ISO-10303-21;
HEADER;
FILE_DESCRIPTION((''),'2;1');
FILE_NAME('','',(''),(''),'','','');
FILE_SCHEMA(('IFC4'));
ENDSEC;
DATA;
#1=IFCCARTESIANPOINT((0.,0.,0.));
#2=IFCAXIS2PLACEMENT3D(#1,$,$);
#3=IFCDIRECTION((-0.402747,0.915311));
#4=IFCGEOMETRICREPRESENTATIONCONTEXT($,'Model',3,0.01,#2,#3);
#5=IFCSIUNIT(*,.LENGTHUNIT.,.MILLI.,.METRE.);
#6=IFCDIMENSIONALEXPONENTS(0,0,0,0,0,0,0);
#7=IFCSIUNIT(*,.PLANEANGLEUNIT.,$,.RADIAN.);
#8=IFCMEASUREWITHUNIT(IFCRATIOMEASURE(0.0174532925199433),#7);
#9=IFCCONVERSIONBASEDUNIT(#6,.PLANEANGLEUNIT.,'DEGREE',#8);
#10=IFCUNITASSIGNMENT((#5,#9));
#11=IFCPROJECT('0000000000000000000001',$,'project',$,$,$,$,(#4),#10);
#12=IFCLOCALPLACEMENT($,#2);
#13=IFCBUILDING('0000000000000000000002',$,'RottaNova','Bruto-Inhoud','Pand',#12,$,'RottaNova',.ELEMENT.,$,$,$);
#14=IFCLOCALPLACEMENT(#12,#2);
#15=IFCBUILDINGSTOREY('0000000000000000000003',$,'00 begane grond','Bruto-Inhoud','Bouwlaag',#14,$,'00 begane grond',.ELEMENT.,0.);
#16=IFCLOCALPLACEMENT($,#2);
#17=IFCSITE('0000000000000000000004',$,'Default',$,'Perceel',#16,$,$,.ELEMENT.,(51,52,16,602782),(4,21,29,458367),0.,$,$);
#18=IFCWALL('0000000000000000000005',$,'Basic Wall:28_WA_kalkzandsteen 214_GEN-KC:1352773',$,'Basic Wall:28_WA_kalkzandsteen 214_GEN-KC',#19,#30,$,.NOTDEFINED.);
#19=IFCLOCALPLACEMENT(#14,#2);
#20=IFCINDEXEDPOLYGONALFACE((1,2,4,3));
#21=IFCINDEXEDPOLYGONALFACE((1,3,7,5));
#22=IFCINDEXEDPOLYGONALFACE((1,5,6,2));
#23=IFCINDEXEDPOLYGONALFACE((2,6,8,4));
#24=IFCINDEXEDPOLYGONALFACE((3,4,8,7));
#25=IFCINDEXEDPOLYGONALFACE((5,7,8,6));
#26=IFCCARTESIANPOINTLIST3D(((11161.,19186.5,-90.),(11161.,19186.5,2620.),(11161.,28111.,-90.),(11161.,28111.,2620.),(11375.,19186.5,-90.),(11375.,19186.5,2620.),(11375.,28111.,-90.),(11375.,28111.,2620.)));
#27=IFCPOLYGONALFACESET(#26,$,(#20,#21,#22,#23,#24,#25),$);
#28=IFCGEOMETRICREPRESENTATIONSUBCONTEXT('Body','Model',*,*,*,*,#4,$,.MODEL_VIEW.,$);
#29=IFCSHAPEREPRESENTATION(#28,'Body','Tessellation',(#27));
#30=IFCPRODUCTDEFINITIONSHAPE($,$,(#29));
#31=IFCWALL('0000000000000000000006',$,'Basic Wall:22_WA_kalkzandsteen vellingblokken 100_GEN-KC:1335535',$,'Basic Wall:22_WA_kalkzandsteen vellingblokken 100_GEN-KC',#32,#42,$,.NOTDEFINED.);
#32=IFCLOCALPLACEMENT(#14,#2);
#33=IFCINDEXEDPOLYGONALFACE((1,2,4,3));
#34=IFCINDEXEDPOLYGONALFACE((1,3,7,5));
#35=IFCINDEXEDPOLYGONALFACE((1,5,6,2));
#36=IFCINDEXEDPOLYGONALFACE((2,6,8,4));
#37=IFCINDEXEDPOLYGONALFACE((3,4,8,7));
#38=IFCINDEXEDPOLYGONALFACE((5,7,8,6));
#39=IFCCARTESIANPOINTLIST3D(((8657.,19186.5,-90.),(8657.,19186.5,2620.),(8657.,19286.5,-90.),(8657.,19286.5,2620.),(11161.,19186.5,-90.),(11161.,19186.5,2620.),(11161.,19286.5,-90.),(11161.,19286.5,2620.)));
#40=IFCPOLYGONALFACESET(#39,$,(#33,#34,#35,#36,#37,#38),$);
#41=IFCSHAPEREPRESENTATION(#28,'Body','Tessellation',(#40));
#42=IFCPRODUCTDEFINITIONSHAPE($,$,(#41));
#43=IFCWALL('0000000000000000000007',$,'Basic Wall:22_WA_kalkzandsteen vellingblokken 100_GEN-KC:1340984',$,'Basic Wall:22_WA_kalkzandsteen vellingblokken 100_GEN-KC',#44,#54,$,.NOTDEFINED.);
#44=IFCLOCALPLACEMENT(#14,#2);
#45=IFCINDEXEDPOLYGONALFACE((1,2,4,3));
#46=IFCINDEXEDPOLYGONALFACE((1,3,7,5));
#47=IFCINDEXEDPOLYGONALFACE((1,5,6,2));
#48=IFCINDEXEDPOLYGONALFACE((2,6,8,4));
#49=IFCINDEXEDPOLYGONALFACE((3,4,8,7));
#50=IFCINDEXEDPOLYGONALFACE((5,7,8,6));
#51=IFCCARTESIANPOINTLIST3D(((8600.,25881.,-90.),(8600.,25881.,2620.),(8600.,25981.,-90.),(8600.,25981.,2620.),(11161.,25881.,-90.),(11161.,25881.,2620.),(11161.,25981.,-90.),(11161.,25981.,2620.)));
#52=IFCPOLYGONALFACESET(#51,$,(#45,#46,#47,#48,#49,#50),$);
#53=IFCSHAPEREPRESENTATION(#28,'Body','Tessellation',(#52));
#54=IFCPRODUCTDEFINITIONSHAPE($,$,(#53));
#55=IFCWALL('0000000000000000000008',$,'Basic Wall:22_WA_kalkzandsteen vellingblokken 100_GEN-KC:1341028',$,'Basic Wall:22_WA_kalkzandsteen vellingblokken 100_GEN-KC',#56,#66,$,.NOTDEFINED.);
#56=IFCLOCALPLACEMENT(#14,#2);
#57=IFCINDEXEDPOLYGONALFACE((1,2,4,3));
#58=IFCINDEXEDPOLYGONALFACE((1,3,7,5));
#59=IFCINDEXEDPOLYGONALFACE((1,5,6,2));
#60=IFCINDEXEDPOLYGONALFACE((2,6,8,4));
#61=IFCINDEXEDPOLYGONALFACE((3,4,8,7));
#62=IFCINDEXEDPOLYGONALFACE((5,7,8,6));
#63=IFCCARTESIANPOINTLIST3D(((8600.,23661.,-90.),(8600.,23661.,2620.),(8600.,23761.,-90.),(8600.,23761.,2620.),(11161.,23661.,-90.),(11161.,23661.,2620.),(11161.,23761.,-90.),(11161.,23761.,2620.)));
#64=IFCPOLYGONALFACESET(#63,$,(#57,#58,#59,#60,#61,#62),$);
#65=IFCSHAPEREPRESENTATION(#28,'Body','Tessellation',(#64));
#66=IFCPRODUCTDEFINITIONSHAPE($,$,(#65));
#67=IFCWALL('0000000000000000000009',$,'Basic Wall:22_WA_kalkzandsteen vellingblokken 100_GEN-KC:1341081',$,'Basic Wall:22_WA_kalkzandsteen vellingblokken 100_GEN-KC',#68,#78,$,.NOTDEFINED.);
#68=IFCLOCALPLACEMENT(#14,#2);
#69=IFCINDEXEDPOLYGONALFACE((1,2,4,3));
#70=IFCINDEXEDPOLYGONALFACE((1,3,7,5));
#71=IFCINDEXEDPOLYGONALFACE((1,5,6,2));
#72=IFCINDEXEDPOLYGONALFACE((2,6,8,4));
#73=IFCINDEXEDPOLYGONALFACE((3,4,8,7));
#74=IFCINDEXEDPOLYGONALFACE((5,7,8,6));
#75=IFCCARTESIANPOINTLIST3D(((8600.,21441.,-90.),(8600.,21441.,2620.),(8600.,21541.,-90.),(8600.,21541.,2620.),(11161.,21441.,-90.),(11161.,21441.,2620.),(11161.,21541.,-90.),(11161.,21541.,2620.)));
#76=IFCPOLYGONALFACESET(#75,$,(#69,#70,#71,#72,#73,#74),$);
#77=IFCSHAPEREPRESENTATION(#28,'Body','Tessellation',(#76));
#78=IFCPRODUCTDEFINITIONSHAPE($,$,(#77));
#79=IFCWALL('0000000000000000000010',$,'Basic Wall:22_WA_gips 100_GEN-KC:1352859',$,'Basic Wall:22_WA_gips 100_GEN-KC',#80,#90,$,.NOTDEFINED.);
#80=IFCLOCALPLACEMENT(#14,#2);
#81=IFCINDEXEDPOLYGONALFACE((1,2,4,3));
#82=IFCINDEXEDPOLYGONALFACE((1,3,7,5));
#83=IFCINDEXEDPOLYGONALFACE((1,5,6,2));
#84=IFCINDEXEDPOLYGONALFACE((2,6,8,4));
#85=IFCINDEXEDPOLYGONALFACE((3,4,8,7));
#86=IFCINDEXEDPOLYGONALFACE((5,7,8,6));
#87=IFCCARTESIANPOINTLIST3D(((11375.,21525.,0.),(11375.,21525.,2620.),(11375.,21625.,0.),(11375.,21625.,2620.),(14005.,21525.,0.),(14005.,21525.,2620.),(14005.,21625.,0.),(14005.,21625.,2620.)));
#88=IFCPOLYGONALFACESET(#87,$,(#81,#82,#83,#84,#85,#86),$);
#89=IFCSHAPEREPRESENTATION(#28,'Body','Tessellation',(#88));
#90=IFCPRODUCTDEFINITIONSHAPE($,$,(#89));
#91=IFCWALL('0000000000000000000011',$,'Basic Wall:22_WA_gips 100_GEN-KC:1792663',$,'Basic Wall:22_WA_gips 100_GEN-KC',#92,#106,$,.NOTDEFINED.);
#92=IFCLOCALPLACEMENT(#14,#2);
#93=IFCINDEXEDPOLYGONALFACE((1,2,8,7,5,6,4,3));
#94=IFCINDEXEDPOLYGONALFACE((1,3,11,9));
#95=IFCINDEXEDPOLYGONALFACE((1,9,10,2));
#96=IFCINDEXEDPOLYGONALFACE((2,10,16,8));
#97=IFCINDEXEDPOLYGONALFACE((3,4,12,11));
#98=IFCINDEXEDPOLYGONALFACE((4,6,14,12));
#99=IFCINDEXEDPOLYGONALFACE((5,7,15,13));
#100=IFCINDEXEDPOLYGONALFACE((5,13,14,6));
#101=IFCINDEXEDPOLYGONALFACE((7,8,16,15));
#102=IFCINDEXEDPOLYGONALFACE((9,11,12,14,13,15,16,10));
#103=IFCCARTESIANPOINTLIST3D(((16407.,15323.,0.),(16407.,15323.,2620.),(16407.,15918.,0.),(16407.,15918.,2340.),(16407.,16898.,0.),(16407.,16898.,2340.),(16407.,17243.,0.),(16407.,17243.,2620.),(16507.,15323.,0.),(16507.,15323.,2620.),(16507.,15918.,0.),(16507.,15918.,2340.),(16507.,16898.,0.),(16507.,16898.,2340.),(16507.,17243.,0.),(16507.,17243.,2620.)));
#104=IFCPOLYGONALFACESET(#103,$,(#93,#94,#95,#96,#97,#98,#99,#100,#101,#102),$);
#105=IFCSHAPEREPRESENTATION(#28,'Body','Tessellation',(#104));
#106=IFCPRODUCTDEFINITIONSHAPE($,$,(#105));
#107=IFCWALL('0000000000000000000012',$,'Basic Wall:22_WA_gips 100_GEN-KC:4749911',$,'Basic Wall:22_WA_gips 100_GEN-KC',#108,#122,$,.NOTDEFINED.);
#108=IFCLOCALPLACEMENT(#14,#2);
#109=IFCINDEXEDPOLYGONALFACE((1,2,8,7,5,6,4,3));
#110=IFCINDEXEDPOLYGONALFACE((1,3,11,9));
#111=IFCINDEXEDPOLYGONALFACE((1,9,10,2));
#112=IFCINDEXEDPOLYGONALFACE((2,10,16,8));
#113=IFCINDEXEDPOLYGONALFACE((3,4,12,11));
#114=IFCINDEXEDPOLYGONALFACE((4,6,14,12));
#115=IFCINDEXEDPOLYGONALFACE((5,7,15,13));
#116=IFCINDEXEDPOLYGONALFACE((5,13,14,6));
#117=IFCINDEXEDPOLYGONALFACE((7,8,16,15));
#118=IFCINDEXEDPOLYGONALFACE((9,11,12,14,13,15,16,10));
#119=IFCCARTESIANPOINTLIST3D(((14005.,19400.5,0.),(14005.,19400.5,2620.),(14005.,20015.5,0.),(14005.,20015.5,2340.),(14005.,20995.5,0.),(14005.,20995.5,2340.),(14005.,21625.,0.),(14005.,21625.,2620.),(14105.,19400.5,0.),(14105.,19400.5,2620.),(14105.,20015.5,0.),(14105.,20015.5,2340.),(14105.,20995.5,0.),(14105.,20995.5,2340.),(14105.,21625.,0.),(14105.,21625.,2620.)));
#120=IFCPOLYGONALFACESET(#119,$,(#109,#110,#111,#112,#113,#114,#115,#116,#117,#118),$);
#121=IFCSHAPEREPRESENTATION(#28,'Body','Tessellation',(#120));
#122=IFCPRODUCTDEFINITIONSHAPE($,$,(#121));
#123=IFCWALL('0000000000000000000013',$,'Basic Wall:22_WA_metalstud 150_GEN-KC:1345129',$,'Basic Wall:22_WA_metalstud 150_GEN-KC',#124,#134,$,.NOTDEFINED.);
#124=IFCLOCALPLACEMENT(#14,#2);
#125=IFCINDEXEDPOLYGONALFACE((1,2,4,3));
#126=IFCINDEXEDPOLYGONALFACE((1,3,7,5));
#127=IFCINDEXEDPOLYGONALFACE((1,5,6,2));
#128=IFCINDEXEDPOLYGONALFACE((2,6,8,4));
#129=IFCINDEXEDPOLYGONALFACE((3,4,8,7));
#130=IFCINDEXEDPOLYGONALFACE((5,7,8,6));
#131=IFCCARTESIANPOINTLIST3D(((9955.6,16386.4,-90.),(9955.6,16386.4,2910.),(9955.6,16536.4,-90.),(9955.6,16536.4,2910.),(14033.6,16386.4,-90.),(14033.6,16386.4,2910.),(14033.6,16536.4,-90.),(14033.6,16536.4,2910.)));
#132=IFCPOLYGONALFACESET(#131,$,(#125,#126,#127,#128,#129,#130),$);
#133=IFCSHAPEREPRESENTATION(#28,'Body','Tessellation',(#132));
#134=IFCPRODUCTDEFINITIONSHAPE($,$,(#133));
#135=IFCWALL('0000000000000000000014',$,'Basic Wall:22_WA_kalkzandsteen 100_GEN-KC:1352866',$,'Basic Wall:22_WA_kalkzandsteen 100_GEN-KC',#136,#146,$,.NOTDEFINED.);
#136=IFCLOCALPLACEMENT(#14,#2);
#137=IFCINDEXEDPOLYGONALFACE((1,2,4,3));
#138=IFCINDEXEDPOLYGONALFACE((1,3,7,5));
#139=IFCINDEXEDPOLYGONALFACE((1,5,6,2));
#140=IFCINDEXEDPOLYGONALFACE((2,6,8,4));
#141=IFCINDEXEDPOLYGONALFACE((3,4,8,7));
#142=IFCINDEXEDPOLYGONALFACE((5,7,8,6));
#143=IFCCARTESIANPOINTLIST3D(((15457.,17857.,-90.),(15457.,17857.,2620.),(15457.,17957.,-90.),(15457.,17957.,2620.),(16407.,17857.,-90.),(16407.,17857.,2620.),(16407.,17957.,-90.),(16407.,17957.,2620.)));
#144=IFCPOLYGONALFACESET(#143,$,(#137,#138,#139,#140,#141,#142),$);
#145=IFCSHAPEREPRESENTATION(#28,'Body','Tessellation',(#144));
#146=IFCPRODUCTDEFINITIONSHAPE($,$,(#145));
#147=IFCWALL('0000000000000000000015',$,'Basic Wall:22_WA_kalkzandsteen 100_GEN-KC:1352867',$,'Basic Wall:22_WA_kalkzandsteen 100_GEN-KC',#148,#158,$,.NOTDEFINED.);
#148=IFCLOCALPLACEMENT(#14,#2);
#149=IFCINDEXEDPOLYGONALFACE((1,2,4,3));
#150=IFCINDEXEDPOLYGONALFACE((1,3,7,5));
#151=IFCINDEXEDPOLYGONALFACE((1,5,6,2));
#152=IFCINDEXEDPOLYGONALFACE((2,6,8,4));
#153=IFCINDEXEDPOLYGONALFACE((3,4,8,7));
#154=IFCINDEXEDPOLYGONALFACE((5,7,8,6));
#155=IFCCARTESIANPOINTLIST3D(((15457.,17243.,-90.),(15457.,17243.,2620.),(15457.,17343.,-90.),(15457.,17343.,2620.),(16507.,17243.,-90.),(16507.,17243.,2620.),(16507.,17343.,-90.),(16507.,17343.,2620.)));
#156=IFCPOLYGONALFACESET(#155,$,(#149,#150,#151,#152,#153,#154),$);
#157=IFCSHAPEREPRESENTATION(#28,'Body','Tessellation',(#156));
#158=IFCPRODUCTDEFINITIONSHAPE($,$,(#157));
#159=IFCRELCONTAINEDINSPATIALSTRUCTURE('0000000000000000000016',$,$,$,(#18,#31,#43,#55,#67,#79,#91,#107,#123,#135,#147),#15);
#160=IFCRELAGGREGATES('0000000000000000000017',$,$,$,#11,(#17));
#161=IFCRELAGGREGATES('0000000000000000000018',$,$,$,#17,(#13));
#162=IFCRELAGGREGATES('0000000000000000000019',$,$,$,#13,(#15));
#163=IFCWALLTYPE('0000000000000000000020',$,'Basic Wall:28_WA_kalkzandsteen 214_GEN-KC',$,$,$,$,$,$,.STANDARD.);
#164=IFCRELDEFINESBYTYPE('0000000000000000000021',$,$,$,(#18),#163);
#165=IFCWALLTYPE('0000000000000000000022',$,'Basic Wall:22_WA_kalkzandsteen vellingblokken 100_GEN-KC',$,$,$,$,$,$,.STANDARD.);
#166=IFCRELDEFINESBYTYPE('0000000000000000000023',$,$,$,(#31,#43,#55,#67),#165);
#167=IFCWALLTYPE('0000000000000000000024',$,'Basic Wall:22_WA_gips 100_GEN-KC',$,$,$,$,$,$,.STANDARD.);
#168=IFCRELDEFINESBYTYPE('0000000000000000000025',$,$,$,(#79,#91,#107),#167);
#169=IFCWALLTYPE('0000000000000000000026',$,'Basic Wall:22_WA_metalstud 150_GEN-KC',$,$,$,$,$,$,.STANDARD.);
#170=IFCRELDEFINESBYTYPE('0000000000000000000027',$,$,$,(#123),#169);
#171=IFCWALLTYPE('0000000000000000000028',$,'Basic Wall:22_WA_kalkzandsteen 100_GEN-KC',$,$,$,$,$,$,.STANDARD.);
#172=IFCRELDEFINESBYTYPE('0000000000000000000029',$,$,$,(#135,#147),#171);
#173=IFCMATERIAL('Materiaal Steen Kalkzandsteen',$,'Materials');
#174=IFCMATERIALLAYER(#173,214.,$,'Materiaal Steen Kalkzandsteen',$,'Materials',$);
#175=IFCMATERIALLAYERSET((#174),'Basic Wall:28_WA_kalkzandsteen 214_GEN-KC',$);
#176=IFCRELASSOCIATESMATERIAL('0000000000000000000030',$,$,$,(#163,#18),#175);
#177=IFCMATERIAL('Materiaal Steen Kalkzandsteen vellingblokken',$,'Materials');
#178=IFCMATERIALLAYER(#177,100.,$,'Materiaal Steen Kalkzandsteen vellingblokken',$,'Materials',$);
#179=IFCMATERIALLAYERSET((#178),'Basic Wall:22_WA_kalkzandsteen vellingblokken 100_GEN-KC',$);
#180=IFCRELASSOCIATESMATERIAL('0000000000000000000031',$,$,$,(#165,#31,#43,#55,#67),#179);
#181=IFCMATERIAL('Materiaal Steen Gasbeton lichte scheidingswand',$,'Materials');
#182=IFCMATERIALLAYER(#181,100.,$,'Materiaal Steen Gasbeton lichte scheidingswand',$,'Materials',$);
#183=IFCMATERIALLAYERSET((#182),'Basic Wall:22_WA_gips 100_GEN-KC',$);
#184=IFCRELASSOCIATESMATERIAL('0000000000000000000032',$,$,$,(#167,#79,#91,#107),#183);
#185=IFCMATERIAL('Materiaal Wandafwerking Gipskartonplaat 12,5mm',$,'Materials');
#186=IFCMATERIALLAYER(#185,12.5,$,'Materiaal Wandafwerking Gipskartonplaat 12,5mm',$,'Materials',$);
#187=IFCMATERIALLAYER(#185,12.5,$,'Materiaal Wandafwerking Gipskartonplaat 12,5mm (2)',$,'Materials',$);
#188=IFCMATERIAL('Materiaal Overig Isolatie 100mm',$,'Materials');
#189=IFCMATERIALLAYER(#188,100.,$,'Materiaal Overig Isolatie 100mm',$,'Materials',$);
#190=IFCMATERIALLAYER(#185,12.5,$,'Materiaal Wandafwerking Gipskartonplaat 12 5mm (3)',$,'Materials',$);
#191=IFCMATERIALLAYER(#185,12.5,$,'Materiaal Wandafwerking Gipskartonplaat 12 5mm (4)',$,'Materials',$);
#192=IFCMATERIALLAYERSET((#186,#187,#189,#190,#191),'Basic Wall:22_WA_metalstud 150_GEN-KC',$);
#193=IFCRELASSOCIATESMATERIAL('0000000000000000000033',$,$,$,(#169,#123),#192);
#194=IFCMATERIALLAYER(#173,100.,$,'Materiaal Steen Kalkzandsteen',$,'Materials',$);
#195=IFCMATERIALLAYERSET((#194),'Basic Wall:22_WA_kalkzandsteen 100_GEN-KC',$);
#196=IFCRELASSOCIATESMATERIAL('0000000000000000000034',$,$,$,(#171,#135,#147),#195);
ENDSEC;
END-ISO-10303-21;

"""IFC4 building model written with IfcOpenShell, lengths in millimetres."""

from ifc_helpers import new_model, entity, si_unit, converted_unit, direction, frame, frame_2d, origin, place, context, subcontext, project, spatial, rectangle, extrude, material, layer, layer_set, type_object, element, save


model = new_model("IFC4")

# Units and contexts
model_context = context("Model", 3, precision=0.01, world=origin(), true_north=direction((-0.402747, 0.915311)))
body_context = subcontext(model_context, "Body", "Model", "MODEL_VIEW")
ifc_project = project(units=[si_unit("LENGTHUNIT", "METRE", prefix="MILLI"), converted_unit("PLANEANGLEUNIT", "DEGREE", entity("IfcRatioMeasure", 0.0174532925199433), si_unit("PLANEANGLEUNIT", "RADIAN"), dimensions=[0, 0, 0, 0, 0, 0, 0])], contexts=[model_context])

# Site, building, storey
site_placement = place(None, origin())
site = spatial("IfcSite", under=ifc_project, at=site_placement, Name="Default", ObjectType="Perceel", CompositionType="ELEMENT", RefLatitude=(51, 52, 16, 602782), RefLongitude=(4, 21, 29, 458367), RefElevation=0.0)
building_placement = place(None, origin())
building = spatial("IfcBuilding", under=site, at=building_placement, Name="RottaNova", Description="Bruto-Inhoud", ObjectType="Pand", LongName="RottaNova", CompositionType="ELEMENT")
storey_placement = place(building_placement, origin())
storey = spatial("IfcBuildingStorey", under=building, at=storey_placement, Name="00 begane grond", Description="Bruto-Inhoud", ObjectType="Bouwlaag", LongName="00 begane grond", CompositionType="ELEMENT", Elevation=0.0)

# Walls
ifc_material_1 = material(Name="Materiaal Steen Kalkzandsteen", Category="Materials")
ifc_layer_1 = layer(ifc_material_1, 214.0, Name="Materiaal Steen Kalkzandsteen", Category="Materials")
ifc_layer_set_1 = layer_set([ifc_layer_1], Name="Basic Wall:28_WA_kalkzandsteen 214_GEN-KC")
wall_type_1 = type_object("IfcWallType", Name="Basic Wall:28_WA_kalkzandsteen 214_GEN-KC", PredefinedType="STANDARD", material=ifc_layer_set_1)
wall_1_placement = place(storey_placement, frame((11268.0, 19186.5, -90.0), z_axis=(0.0, 0.0, 1.0), x_axis=(0.0, 1.0, 0.0)))
element("IfcWall", 1, at=wall_1_placement, inside=storey, type_object=wall_type_1, material=ifc_layer_set_1, Name="Basic Wall:28_WA_kalkzandsteen 214_GEN-KC:1352773", ObjectType="Basic Wall:28_WA_kalkzandsteen 214_GEN-KC", PredefinedType="NOTDEFINED", context=body_context, shape_type="SweptSolid", body=[
    extrude(rectangle(XDim=8924.5, YDim=214.0, at=frame_2d((4462.2, 0.0), x_axis=(-1.0, 0.0))), origin(), (0.0, 0.0, 1.0), 2710.0),
])
ifc_material_2 = material(Name="Materiaal Steen Kalkzandsteen vellingblokken", Category="Materials")
ifc_layer_2 = layer(ifc_material_2, 100.0, Name="Materiaal Steen Kalkzandsteen vellingblokken", Category="Materials")
ifc_layer_set_2 = layer_set([ifc_layer_2], Name="Basic Wall:22_WA_kalkzandsteen vellingblokken 100_GEN-KC")
wall_type_2 = type_object("IfcWallType", Name="Basic Wall:22_WA_kalkzandsteen vellingblokken 100_GEN-KC", PredefinedType="STANDARD", material=ifc_layer_set_2)
wall_2_placement = place(storey_placement, frame((8657.0, 19236.5, -90.0)))
element("IfcWall", 2, at=wall_2_placement, inside=storey, type_object=wall_type_2, material=ifc_layer_set_2, Name="Basic Wall:22_WA_kalkzandsteen vellingblokken 100_GEN-KC:1335535", ObjectType="Basic Wall:22_WA_kalkzandsteen vellingblokken 100_GEN-KC", PredefinedType="NOTDEFINED", context=body_context, shape_type="SweptSolid", body=[
    extrude(rectangle(XDim=2504.0, YDim=100.0, at=frame_2d((1252.0, 0.0), x_axis=(-1.0, 0.0))), origin(), (0.0, 0.0, 1.0), 2710.0),
])
for number, where, name in (
    (3, (8600.0, 25931.0, -90.0), "Basic Wall:22_WA_kalkzandsteen vellingblokken 100_GEN-KC:1340984"),
    (4, (8600.0, 23711.0, -90.0), "Basic Wall:22_WA_kalkzandsteen vellingblokken 100_GEN-KC:1341028"),
    (5, (8600.0, 21491.0, -90.0), "Basic Wall:22_WA_kalkzandsteen vellingblokken 100_GEN-KC:1341081"),
):
    element("IfcWall", number, at=place(storey_placement, frame(where)), inside=storey, type_object=wall_type_2, material=ifc_layer_set_2, Name=name, ObjectType="Basic Wall:22_WA_kalkzandsteen vellingblokken 100_GEN-KC", PredefinedType="NOTDEFINED", context=body_context, shape_type="SweptSolid", body=[
        extrude(rectangle(XDim=2561.0, YDim=100.0, at=frame_2d((1280.5, 0.0), x_axis=(-1.0, 0.0))), origin(), (0.0, 0.0, 1.0), 2710.0),
    ])
ifc_material_3 = material(Name="Materiaal Steen Gasbeton lichte scheidingswand", Category="Materials")
ifc_layer_3 = layer(ifc_material_3, 100.0, Name="Materiaal Steen Gasbeton lichte scheidingswand", Category="Materials")
ifc_layer_set_3 = layer_set([ifc_layer_3], Name="Basic Wall:22_WA_gips 100_GEN-KC")
wall_type_3 = type_object("IfcWallType", Name="Basic Wall:22_WA_gips 100_GEN-KC", PredefinedType="STANDARD", material=ifc_layer_set_3)
wall_3_placement = place(storey_placement, frame((14005.0, 21575.0, 0.0), z_axis=(0.0, 0.0, 1.0), x_axis=(-1.0, 0.0, 0.0)))
element("IfcWall", 6, at=wall_3_placement, inside=storey, type_object=wall_type_3, material=ifc_layer_set_3, Name="Basic Wall:22_WA_gips 100_GEN-KC:1352859", ObjectType="Basic Wall:22_WA_gips 100_GEN-KC", PredefinedType="NOTDEFINED", context=body_context, shape_type="SweptSolid", body=[
    extrude(rectangle(XDim=2630.0, YDim=100.0, at=frame_2d((1315.0, 0.0), x_axis=(-1.0, 0.0))), origin(), (0.0, 0.0, 1.0), 2620.0),
])

# Walls, openings
wall_4_placement = place(storey_placement, frame((16457.0, 17243.0, 0.0), z_axis=(0.0, 0.0, 1.0), x_axis=(0.0, -1.0, 0.0)))
wall_4 = element("IfcWall", 7, at=wall_4_placement, inside=storey, type_object=wall_type_3, material=ifc_layer_set_3, Name="Basic Wall:22_WA_gips 100_GEN-KC:1792663", ObjectType="Basic Wall:22_WA_gips 100_GEN-KC", PredefinedType="NOTDEFINED", context=body_context, shape_type="SweptSolid", body=[
    extrude(rectangle(XDim=1920.0, YDim=100.0, at=frame_2d((960.0, 0.0), x_axis=(1.0, 0.0))), origin(), (0.0, 0.0, 1.0), 2620.0),
])
opening_1_placement = place(wall_4_placement, frame((345.0, -50.0, -90.0)))
element("IfcOpeningElement", 8, at=opening_1_placement, cuts=wall_4, PredefinedType="OPENING", context=body_context, shape_type="SweptSolid", body=[
    extrude(rectangle(XDim=2430.0, YDim=980.0, at=frame_2d((1215.0, 490.0), x_axis=(1.0, 0.0))), frame((0.0, 0.0, 0.0), z_axis=(0.0, 1.0, 0.0), x_axis=(0.0, 0.0, 1.0)), (0.0, 0.0, 1.0), 100.0),
])
wall_5_placement = place(storey_placement, frame((14055.0, 21625.0, 0.0), z_axis=(0.0, 0.0, 1.0), x_axis=(0.0, -1.0, 0.0)))
wall_5 = element("IfcWall", 9, at=wall_5_placement, inside=storey, type_object=wall_type_3, material=ifc_layer_set_3, Name="Basic Wall:22_WA_gips 100_GEN-KC:4749911", ObjectType="Basic Wall:22_WA_gips 100_GEN-KC", PredefinedType="NOTDEFINED", context=body_context, shape_type="SweptSolid", body=[
    extrude(rectangle(XDim=2224.5, YDim=100.0, at=frame_2d((1112.3, 0.0), x_axis=(1.0, 0.0))), origin(), (0.0, 0.0, 1.0), 2620.0),
])
opening_2_placement = place(wall_5_placement, frame((629.5, -50.0, -90.0)))
element("IfcOpeningElement", 10, at=opening_2_placement, cuts=wall_5, PredefinedType="OPENING", context=body_context, shape_type="SweptSolid", body=[
    extrude(rectangle(XDim=2430.0, YDim=980.0, at=frame_2d((1215.0, 490.0), x_axis=(1.0, 0.0))), frame((0.0, 0.0, 0.0), z_axis=(0.0, 1.0, 0.0), x_axis=(0.0, 0.0, 1.0)), (0.0, 0.0, 1.0), 100.0),
])

# Walls
ifc_material_4 = material(Name="Materiaal Wandafwerking Gipskartonplaat 12,5mm", Category="Materials")
ifc_layer_4 = layer(ifc_material_4, 12.5, Name="Materiaal Wandafwerking Gipskartonplaat 12,5mm", Category="Materials")
ifc_layer_5 = layer(ifc_material_4, 12.5, Name="Materiaal Wandafwerking Gipskartonplaat 12,5mm (2)", Category="Materials")
ifc_material_5 = material(Name="Materiaal Overig Isolatie 100mm", Category="Materials")
ifc_layer_6 = layer(ifc_material_5, 100.0, Name="Materiaal Overig Isolatie 100mm", Category="Materials")
ifc_layer_7 = layer(ifc_material_4, 12.5, Name="Materiaal Wandafwerking Gipskartonplaat 12 5mm (3)", Category="Materials")
ifc_layer_8 = layer(ifc_material_4, 12.5, Name="Materiaal Wandafwerking Gipskartonplaat 12 5mm (4)", Category="Materials")
ifc_layer_set_4 = layer_set([ifc_layer_4, ifc_layer_5, ifc_layer_6, ifc_layer_7, ifc_layer_8], Name="Basic Wall:22_WA_metalstud 150_GEN-KC")
wall_type_4 = type_object("IfcWallType", Name="Basic Wall:22_WA_metalstud 150_GEN-KC", PredefinedType="STANDARD", material=ifc_layer_set_4)
wall_6_placement = place(storey_placement, frame((9955.6, 16461.4, -90.0)))
element("IfcWall", 11, at=wall_6_placement, inside=storey, type_object=wall_type_4, material=ifc_layer_set_4, Name="Basic Wall:22_WA_metalstud 150_GEN-KC:1345129", ObjectType="Basic Wall:22_WA_metalstud 150_GEN-KC", PredefinedType="NOTDEFINED", context=body_context, shape_type="SweptSolid", body=[
    extrude(rectangle(XDim=4078.0, YDim=150.0, at=frame_2d((2039.0, 0.0), x_axis=(-1.0, 0.0))), origin(), (0.0, 0.0, 1.0), 3000.0),
])
ifc_layer_9 = layer(ifc_material_1, 100.0, Name="Materiaal Steen Kalkzandsteen", Category="Materials")
ifc_layer_set_5 = layer_set([ifc_layer_9], Name="Basic Wall:22_WA_kalkzandsteen 100_GEN-KC")
wall_type_5 = type_object("IfcWallType", Name="Basic Wall:22_WA_kalkzandsteen 100_GEN-KC", PredefinedType="STANDARD", material=ifc_layer_set_5)
wall_7_placement = place(storey_placement, frame((16407.0, 17907.0, -90.0), z_axis=(0.0, 0.0, 1.0), x_axis=(-1.0, 0.0, 0.0)))
element("IfcWall", 12, at=wall_7_placement, inside=storey, type_object=wall_type_5, material=ifc_layer_set_5, Name="Basic Wall:22_WA_kalkzandsteen 100_GEN-KC:1352866", ObjectType="Basic Wall:22_WA_kalkzandsteen 100_GEN-KC", PredefinedType="NOTDEFINED", context=body_context, shape_type="SweptSolid", body=[
    extrude(rectangle(XDim=950.0, YDim=100.0, at=frame_2d((475.0, 0.0), x_axis=(-1.0, 0.0))), origin(), (0.0, 0.0, 1.0), 2710.0),
])
wall_8_placement = place(storey_placement, frame((16507.0, 17293.0, -90.0), z_axis=(0.0, 0.0, 1.0), x_axis=(-1.0, 0.0, 0.0)))
element("IfcWall", 13, at=wall_8_placement, inside=storey, type_object=wall_type_5, material=ifc_layer_set_5, Name="Basic Wall:22_WA_kalkzandsteen 100_GEN-KC:1352867", ObjectType="Basic Wall:22_WA_kalkzandsteen 100_GEN-KC", PredefinedType="NOTDEFINED", context=body_context, shape_type="SweptSolid", body=[
    extrude(rectangle(XDim=1050.0, YDim=100.0, at=frame_2d((525.0, 0.0), x_axis=(-1.0, 0.0))), origin(), (0.0, 0.0, 1.0), 2710.0),
])

save(model, "model.ifc")
